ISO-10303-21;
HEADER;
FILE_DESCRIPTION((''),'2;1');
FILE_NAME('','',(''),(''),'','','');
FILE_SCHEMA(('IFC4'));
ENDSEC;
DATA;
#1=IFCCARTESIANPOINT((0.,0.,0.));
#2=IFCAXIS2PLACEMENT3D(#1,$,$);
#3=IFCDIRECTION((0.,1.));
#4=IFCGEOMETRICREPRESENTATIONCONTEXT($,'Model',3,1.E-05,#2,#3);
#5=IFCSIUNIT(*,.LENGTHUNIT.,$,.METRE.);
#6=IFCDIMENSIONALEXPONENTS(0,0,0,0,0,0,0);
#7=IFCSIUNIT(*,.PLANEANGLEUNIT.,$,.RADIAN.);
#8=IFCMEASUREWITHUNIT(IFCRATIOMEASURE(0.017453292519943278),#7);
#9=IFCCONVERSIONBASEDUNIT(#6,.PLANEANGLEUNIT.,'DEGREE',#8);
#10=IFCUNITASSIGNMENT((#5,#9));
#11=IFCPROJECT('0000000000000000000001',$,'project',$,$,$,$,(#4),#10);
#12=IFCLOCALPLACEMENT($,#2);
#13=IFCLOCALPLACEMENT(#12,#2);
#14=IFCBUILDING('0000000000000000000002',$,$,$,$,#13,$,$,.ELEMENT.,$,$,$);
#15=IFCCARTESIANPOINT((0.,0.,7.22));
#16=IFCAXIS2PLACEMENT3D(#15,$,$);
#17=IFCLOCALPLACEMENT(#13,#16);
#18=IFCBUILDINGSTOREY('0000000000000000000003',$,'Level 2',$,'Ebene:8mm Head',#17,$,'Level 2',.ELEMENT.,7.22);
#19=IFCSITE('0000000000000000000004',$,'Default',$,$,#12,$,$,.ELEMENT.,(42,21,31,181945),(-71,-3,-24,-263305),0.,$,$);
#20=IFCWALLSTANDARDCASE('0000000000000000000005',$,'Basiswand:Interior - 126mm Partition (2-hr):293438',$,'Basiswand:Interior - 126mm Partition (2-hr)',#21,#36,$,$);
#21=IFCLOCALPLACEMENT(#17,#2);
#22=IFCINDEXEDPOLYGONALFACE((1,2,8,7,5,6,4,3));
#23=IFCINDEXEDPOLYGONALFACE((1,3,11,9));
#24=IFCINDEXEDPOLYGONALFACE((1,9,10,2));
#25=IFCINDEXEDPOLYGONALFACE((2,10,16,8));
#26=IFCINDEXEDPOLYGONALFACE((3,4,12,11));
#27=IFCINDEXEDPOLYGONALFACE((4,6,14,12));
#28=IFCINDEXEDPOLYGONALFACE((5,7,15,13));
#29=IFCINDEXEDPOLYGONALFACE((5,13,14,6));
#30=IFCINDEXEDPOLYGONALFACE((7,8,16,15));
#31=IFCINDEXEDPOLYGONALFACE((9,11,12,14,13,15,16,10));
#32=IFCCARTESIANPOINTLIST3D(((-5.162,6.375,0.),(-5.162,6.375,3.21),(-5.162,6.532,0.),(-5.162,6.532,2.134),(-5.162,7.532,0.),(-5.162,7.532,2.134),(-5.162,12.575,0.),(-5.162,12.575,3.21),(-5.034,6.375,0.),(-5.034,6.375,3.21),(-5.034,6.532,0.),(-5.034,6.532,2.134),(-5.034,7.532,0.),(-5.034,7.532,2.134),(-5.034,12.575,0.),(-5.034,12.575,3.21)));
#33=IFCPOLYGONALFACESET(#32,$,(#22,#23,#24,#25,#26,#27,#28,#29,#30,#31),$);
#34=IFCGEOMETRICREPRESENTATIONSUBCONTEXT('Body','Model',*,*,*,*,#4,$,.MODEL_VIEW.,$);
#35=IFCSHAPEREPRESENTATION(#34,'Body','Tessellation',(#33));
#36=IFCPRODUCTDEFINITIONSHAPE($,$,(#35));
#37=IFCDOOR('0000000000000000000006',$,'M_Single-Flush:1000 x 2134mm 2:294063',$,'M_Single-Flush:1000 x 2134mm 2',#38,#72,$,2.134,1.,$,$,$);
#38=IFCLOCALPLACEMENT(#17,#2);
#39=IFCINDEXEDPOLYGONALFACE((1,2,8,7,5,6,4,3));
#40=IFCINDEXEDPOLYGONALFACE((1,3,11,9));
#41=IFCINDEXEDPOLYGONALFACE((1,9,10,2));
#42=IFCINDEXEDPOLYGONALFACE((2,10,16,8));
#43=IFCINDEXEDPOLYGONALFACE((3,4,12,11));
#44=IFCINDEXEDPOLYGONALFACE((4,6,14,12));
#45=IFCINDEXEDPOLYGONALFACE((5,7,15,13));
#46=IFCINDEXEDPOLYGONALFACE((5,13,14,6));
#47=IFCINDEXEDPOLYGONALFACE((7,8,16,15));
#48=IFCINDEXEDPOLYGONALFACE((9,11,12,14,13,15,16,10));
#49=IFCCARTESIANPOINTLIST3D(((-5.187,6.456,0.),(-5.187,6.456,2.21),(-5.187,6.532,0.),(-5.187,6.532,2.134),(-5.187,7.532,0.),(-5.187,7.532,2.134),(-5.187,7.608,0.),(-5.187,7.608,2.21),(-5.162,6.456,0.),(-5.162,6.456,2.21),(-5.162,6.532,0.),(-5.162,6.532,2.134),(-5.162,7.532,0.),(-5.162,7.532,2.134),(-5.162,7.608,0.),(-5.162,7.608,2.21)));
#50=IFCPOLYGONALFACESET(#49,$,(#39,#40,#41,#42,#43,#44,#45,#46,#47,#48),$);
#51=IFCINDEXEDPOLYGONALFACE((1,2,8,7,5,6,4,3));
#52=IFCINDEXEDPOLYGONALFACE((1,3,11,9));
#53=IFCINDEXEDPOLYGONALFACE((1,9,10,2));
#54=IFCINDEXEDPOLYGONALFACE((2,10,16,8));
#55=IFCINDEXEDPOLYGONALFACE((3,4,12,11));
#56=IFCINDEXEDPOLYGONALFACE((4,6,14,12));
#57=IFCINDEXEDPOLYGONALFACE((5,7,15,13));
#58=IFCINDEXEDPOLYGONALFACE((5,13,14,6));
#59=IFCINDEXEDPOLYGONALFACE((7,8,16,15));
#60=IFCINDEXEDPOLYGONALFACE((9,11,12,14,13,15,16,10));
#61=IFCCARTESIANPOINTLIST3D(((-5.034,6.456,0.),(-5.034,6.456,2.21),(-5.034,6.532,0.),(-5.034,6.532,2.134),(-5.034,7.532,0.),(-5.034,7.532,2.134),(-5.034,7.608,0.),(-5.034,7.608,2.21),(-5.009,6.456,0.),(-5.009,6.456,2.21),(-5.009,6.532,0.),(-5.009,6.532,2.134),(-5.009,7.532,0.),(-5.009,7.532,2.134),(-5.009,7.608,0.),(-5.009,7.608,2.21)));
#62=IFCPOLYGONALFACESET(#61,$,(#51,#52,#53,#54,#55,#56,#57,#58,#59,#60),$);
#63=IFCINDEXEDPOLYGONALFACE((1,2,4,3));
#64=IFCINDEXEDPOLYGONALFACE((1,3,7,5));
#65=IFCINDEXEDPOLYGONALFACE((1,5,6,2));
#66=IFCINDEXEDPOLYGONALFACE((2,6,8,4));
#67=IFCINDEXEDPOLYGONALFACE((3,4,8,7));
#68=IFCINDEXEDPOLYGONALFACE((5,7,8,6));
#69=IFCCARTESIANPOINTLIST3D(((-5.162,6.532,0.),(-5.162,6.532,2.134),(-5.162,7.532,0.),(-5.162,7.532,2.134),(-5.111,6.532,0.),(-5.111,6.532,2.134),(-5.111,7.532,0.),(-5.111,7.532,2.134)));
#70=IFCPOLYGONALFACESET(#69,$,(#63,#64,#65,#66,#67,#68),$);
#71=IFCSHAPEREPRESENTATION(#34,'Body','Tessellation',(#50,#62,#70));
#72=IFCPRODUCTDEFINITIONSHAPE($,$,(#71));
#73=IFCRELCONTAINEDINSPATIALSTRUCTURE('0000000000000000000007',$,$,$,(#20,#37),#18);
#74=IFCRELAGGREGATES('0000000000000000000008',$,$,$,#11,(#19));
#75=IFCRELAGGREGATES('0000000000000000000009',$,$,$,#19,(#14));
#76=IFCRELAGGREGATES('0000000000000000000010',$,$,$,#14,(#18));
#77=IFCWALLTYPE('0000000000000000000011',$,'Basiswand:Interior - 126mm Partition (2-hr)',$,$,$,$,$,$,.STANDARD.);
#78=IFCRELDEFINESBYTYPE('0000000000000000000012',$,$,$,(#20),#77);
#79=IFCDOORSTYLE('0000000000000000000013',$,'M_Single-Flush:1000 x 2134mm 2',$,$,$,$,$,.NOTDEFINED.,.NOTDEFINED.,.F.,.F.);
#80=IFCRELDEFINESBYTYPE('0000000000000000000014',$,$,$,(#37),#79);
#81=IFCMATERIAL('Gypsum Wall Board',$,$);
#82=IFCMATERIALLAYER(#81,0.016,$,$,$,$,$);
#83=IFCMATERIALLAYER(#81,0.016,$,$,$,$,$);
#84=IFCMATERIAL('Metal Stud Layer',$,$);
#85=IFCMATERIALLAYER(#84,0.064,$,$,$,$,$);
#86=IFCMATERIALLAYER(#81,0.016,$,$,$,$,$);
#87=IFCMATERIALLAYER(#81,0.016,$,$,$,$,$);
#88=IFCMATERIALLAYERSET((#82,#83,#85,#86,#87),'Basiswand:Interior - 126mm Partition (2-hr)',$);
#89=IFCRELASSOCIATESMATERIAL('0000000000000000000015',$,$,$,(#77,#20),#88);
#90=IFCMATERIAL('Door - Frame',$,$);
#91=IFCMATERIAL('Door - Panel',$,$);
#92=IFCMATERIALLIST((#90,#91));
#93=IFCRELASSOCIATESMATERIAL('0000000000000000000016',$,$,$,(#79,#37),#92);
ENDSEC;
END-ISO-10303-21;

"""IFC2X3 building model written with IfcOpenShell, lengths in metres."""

from ifc_helpers import new_model, entity, si_unit, converted_unit, direction, frame, frame_2d, origin, place, context, subcontext, project, spatial, polyline, rectangle, outline, extrude, clip, bounded_halfspace, source, transform, mapped, material, material_list, layer, layer_set, layer_usage, type_object, type_shapes, element, fill, save


model = new_model("IFC2X3")

# Units and contexts
model_context = context("Model", 3, precision=1e-05, world=origin(), true_north=direction((0.0, 1.0)))
body_context = subcontext(model_context, "Body", "Model", "MODEL_VIEW")
ifc_project = project(units=[si_unit("LENGTHUNIT", "METRE"), converted_unit("PLANEANGLEUNIT", "DEGREE", entity("IfcRatioMeasure", 0.017453292519943278), si_unit("PLANEANGLEUNIT", "RADIAN"), dimensions=[0, 0, 0, 0, 0, 0, 0])], contexts=[model_context])

# Site, building, storey
site_placement = place(None, origin())
site = spatial("IfcSite", under=ifc_project, at=site_placement, Name="Default", CompositionType="ELEMENT", RefLatitude=(42, 21, 31, 181945), RefLongitude=(-71, -3, -24, -263305), RefElevation=0.0)
building_placement = place(site_placement, origin())
building = spatial("IfcBuilding", under=site, at=building_placement, CompositionType="ELEMENT")
storey_placement = place(building_placement, frame((0.0, 0.0, 7.22)))
storey = spatial("IfcBuildingStorey", under=building, at=storey_placement, Name="Level 2", ObjectType="Ebene:8mm Head", LongName="Level 2", CompositionType="ELEMENT", Elevation=7.22)

# Wall, opening, door
ifc_material_1 = material(Name="Gypsum Wall Board")
ifc_layer_1 = layer(ifc_material_1, 0.016)
ifc_layer_2 = layer(ifc_material_1, 0.016)
ifc_material_2 = material(Name="Metal Stud Layer")
ifc_layer_3 = layer(ifc_material_2, 0.064)
ifc_layer_4 = layer(ifc_material_1, 0.016)
ifc_layer_5 = layer(ifc_material_1, 0.016)
ifc_layer_set = layer_set([ifc_layer_1, ifc_layer_2, ifc_layer_3, ifc_layer_4, ifc_layer_5], Name="Basiswand:Interior - 126mm Partition (2-hr)")
ifc_layer_usage = layer_usage(ifc_layer_set, "AXIS2", "POSITIVE", -0.064)
wall_type = type_object("IfcWallType", Name="Basiswand:Interior - 126mm Partition (2-hr)", PredefinedType="STANDARD", material=ifc_layer_set)
wall_1_placement = place(storey_placement, frame((-5.098, 6.375, 0.0), z_axis=(0.0, 0.0, 1.0), x_axis=(0.0, 1.0, 0.0)))
wall_1 = element("IfcWallStandardCase", 1, at=wall_1_placement, inside=storey, type_object=wall_type, material=ifc_layer_usage, Name="Basiswand:Interior - 126mm Partition (2-hr):293438", ObjectType="Basiswand:Interior - 126mm Partition (2-hr)", context=body_context, shape_type="Clipping", body=[
    clip(extrude(rectangle(XDim=6.2, YDim=0.128, at=frame_2d((3.1, 0.0), x_axis=(1.0, 0.0))), origin(), (0.0, 0.0, 1.0), 3.21), bounded_halfspace(frame((0.0, -0.064, 3.21), z_axis=(0.0, 0.0, -1.0), x_axis=(1.0, 0.0, 0.0)), True, frame((0.0, -0.064, 3.21)), polyline([(0.0, 0.0), (1.25, 0.0), (1.378, 0.0), (6.2, 0.0), (6.2, 0.128), (0.0, 0.128), (0.0, 0.0)]))),
])
opening_1_placement = place(wall_1_placement, frame((0.157, -0.064, 0.0)))
opening_1 = element("IfcOpeningElement", 2, at=opening_1_placement, cuts=wall_1, ObjectType="Opening", context=body_context, shape_type="SweptSolid", body=[
    extrude(rectangle(XDim=1.0, YDim=2.134, at=frame_2d((1.067, 0.5), x_axis=(0.0, -1.0))), frame((0.0, 0.0, 0.0), z_axis=(0.0, 1.0, 0.0), x_axis=(0.0, 0.0, 1.0)), (0.0, 0.0, 1.0), 0.128),
])
ifc_material_3 = material(Name="Door - Frame")
ifc_material_4 = material(Name="Door - Panel")
ifc_material_list = material_list([ifc_material_3, ifc_material_4])
door_style_1 = type_object("IfcDoorStyle", Name="M_Single-Flush:1000 x 2134mm 2", ConstructionType="NOTDEFINED", OperationType="NOTDEFINED", ParameterTakesPrecedence=False, Sizeable=False, material=ifc_material_list)
shared_shape_1 = source(origin(), body_context, "Body", "SweptSolid", [
    extrude(outline(polyline([(-0.576, -1.124), (0.576, -1.124), (0.576, 1.086), (0.5, 1.086), (0.5, -1.048), (-0.5, -1.048), (-0.5, 1.086), (-0.576, 1.086), (-0.576, -1.124)])), frame((0.5, 0.153, 1.086), z_axis=(0.0, -1.0, 0.0), x_axis=(-1.0, 0.0, 0.0)), (0.0, 0.0, 1.0), 0.025),
    extrude(outline(polyline([(-1.124, -0.576), (1.086, -0.576), (1.086, -0.5), (-1.048, -0.5), (-1.048, 0.5), (1.086, 0.5), (1.086, 0.576), (-1.124, 0.576), (-1.124, -0.576)])), frame((0.5, 0.0, 1.086), z_axis=(0.0, -1.0, 0.0), x_axis=(0.0, 0.0, -1.0)), (0.0, 0.0, 1.0), 0.025),
    extrude(rectangle(XDim=1.0, YDim=0.051, at=frame_2d((0.0, 0.0), x_axis=(1.0, 0.0))), frame((0.5, 0.1025, 0.0)), (0.0, 0.0, 1.0), 2.134),
])
type_shapes(door_style_1, [shared_shape_1])
door_1_placement = place(opening_1_placement, origin())
door_1 = element("IfcDoor", 3, at=door_1_placement, inside=storey, type_object=door_style_1, material=ifc_material_list, Name="M_Single-Flush:1000 x 2134mm 2:294063", ObjectType="M_Single-Flush:1000 x 2134mm 2", OverallHeight=2.134, OverallWidth=1.0, context=body_context, shape_type="MappedRepresentation", body=[
    mapped(shared_shape_1, transform((0.0, 0.0, 0.0), scale=1.0)),
])
fill(opening_1, door_1)

save(model, "model.ifc")
